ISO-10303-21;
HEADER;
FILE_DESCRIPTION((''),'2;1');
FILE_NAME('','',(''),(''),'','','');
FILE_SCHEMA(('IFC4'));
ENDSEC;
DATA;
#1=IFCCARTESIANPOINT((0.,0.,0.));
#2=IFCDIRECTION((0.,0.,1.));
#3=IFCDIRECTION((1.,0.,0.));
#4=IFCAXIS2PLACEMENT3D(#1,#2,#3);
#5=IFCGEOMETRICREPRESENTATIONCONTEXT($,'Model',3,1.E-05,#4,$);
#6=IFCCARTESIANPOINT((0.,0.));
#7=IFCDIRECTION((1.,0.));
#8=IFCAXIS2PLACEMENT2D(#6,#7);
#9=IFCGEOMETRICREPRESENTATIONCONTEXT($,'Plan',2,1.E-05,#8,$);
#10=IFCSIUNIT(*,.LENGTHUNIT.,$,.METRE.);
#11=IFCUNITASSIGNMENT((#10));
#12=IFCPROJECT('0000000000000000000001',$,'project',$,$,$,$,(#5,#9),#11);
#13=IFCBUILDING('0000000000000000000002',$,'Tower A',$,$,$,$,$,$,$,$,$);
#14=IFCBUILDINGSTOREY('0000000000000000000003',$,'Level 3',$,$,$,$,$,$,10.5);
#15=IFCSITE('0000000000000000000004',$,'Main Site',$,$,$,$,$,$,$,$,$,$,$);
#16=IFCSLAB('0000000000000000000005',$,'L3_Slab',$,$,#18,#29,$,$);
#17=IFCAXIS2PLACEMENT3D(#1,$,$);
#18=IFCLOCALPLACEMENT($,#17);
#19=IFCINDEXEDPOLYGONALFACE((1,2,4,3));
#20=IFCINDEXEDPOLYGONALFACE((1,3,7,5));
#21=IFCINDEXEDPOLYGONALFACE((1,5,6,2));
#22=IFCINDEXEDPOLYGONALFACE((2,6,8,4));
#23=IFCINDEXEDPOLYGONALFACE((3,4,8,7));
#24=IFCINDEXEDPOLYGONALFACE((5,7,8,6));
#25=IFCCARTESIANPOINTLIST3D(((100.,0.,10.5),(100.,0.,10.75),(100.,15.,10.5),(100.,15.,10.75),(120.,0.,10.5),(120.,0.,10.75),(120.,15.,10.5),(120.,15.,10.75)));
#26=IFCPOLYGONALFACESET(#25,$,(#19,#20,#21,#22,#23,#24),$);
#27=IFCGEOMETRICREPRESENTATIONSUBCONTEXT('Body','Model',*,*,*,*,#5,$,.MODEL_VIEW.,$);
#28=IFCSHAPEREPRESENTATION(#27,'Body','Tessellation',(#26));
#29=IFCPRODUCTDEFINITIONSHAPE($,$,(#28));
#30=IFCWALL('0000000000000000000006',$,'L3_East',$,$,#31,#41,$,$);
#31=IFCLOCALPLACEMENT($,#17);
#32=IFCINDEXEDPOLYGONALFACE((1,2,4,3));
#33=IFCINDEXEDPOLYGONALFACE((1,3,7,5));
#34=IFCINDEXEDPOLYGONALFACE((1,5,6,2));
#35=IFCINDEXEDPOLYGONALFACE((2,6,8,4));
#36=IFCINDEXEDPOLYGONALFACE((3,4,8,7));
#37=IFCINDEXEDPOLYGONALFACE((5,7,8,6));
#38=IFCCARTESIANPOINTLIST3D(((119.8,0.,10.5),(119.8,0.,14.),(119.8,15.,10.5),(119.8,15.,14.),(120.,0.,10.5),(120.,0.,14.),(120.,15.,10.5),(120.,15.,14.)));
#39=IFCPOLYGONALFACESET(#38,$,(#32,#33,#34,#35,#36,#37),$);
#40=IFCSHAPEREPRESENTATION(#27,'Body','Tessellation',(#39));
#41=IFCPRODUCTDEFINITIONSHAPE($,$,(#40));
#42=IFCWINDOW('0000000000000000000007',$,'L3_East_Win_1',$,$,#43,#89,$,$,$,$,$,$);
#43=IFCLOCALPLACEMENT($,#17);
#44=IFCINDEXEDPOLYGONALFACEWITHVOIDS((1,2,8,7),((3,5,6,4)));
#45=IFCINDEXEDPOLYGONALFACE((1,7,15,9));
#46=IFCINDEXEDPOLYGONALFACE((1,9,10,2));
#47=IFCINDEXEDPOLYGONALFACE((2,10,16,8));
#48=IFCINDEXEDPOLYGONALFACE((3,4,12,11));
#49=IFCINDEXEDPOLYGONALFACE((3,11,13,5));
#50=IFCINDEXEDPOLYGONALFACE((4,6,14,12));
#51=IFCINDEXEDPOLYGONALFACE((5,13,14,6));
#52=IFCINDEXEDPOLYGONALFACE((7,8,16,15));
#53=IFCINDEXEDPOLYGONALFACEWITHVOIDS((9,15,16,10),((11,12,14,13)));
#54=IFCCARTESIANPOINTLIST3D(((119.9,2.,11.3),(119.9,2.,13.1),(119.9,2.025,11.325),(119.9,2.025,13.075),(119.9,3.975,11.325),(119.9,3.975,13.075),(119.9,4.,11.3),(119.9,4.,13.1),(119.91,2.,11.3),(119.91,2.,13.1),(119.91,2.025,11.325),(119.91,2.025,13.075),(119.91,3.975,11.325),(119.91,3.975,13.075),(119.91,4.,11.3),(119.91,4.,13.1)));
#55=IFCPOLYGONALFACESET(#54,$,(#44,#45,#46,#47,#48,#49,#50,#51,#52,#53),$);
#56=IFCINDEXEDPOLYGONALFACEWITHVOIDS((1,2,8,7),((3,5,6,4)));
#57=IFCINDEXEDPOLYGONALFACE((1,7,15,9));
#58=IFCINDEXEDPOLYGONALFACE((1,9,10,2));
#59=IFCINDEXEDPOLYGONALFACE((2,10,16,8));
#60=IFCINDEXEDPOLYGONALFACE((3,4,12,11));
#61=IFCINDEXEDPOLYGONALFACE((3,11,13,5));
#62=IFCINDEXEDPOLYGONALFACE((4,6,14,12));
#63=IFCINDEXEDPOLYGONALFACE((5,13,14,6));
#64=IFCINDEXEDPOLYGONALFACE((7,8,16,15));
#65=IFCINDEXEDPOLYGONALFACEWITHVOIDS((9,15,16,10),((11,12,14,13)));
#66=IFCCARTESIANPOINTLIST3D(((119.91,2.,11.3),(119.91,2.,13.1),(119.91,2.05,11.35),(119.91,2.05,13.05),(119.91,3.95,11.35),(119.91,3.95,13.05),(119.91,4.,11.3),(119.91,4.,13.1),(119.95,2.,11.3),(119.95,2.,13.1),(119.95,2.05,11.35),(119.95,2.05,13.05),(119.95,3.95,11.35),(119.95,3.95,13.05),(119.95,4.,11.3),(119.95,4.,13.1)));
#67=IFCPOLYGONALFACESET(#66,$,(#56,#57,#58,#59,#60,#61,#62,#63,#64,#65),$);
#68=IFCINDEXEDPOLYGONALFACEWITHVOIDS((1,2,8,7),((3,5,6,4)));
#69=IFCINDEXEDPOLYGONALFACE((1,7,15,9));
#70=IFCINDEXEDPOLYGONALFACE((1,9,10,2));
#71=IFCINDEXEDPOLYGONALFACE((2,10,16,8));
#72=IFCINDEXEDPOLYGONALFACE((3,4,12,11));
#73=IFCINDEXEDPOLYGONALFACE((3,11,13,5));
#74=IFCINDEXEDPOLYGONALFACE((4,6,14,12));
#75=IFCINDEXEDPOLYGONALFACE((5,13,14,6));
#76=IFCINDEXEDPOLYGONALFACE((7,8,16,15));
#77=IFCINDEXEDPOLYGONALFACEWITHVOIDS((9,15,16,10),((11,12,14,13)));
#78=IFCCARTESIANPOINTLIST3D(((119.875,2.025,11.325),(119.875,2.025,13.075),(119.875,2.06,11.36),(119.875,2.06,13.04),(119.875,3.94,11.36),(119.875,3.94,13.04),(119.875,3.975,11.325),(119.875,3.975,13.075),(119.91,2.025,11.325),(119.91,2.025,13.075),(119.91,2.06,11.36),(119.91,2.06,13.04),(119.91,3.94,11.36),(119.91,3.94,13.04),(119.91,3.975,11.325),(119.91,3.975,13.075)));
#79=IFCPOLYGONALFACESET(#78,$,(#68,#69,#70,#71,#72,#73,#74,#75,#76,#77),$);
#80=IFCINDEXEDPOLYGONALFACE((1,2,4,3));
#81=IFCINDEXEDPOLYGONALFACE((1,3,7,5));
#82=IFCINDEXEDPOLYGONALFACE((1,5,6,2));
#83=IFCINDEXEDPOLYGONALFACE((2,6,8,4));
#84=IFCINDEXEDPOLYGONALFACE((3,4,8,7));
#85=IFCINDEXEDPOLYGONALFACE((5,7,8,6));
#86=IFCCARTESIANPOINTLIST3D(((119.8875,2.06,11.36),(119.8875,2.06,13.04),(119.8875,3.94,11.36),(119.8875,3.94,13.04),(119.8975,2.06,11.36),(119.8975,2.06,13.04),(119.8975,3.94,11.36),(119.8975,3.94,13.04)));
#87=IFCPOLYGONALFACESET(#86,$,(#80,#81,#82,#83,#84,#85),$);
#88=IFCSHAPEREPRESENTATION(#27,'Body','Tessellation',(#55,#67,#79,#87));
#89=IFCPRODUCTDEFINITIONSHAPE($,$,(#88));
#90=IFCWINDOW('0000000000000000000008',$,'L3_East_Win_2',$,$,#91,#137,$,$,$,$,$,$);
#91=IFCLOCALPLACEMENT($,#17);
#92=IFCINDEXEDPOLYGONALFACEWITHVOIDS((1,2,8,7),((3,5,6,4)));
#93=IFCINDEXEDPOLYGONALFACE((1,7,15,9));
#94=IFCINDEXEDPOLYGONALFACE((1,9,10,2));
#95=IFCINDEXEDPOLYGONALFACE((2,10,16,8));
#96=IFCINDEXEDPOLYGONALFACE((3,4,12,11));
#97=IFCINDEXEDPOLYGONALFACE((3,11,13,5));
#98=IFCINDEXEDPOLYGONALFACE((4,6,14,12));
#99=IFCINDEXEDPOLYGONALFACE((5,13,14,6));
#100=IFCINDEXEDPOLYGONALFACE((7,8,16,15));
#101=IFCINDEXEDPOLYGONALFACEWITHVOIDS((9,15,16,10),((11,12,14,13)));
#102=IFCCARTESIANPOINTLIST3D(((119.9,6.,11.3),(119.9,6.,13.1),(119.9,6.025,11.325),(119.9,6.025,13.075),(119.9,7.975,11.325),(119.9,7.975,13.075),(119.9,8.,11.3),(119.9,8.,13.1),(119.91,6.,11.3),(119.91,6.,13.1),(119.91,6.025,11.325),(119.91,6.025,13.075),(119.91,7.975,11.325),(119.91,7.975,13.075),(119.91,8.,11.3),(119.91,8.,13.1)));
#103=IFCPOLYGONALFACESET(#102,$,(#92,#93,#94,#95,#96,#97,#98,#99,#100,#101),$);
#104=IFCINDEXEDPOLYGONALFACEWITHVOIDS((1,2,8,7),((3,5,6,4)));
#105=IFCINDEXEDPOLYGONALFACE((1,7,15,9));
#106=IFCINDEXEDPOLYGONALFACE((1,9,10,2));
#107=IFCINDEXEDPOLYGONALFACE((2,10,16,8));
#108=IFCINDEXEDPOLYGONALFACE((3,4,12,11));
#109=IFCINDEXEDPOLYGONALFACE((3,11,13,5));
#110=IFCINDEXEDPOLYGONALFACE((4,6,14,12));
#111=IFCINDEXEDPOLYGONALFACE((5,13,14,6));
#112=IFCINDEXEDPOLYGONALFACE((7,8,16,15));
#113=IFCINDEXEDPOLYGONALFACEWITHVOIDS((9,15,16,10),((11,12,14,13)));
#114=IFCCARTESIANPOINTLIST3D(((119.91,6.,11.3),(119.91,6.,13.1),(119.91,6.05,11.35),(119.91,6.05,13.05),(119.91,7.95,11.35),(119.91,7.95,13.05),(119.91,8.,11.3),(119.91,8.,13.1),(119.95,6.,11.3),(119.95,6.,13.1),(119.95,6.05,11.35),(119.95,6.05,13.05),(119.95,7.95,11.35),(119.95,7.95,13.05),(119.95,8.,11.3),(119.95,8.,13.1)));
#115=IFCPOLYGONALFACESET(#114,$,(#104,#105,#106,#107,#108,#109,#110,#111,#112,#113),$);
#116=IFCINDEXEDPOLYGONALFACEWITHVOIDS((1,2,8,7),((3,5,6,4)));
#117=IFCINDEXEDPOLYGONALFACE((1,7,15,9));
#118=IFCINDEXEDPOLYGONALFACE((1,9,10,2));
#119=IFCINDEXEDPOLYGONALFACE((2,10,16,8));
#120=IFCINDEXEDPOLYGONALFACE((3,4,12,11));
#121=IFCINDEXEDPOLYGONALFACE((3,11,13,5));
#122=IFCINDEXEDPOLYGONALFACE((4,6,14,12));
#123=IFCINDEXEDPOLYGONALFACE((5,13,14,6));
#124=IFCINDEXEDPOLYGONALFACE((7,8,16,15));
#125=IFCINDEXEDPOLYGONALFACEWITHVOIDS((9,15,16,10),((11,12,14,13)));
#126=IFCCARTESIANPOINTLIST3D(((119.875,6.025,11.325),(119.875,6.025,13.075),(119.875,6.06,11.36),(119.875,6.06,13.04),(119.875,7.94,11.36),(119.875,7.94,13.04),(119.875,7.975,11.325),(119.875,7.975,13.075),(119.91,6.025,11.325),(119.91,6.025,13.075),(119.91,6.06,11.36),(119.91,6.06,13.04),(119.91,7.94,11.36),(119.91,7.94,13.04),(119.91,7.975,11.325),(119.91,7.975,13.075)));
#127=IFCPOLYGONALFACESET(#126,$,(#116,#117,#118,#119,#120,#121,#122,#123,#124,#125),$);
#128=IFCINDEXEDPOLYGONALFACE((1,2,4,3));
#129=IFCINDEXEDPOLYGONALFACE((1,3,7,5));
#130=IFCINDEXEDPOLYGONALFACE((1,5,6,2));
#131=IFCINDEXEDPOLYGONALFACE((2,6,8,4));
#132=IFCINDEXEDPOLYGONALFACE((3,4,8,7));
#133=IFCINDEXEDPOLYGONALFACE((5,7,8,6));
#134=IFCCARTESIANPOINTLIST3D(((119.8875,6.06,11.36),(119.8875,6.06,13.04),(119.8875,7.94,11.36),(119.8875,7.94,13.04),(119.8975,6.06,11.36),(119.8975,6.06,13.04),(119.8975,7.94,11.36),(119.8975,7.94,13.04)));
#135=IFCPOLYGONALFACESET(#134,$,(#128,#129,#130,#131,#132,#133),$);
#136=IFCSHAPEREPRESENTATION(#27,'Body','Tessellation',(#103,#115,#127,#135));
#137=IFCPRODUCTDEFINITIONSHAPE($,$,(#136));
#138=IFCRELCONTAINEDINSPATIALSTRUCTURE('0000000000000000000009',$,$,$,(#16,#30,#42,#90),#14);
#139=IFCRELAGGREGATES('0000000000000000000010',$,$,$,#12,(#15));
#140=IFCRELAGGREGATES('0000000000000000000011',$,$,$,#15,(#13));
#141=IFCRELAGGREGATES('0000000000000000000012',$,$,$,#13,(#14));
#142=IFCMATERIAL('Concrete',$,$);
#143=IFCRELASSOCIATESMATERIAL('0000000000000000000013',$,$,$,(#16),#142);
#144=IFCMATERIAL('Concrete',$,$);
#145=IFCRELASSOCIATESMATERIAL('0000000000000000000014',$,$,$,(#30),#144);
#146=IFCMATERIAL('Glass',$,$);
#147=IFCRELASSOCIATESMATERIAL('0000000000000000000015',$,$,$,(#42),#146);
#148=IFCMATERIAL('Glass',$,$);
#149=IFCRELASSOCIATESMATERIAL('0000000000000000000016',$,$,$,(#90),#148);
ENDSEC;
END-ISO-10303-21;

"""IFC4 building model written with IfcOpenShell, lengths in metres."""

from ifc_helpers import new_model, si_unit, frame, origin_with_axes, origin_2d_with_axis, place, context, subcontext, project, spatial, line, indexed_curve, outline, extrude, material, element, fill, save


model = new_model("IFC4")

# Units and contexts
model_context = context("Model", 3, precision=1e-05, world=origin_with_axes())
plan_context = context("Plan", 2, precision=1e-05, world=origin_2d_with_axis())
body_context = subcontext(model_context, "Body", "Model", "MODEL_VIEW")
ifc_project = project(units=[si_unit("LENGTHUNIT", "METRE")], contexts=[model_context, plan_context])

# Site, building, storey
site = spatial("IfcSite", under=ifc_project, Name="Main Site")
building = spatial("IfcBuilding", under=site, Name="Tower A")
storey = spatial("IfcBuildingStorey", under=building, Name="Level 3", Elevation=10.5)

# Slab
ifc_material_1 = material(Name="Concrete")
slab_placement = place(None, frame((100.0, 0.0, 10.5), z_axis=(0.0, 0.0, 1.0), x_axis=(1.0, 0.0, 0.0)))
element("IfcSlab", 1, at=slab_placement, inside=storey, material=ifc_material_1, Name="L3_Slab", context=body_context, shape_type="SweptSolid", body=[
    extrude(outline(indexed_curve([(0.0, 0.0), (20.0, 0.0), (20.0, 15.0), (0.0, 15.0)])), None, (0.0, 0.0, 1.0), 0.25),
])

# Wall, openings, windows
ifc_material_2 = material(Name="Concrete")
wall_1_placement = place(None, frame((120.0, 0.0, 10.5), z_axis=(0.0, 0.0, 1.0), x_axis=(0.0, 1.0, 0.0)))
wall_1 = element("IfcWall", 2, at=wall_1_placement, inside=storey, material=ifc_material_2, Name="L3_East", context=body_context, shape_type="SweptSolid", body=[
    extrude(outline(indexed_curve([(0.0, 0.0), (0.0, 0.2), (15.0, 0.2), (15.0, 0.0), (0.0, 0.0)], self_intersect=False)), origin_with_axes(), (0.0, 0.0, 1.0), 3.5),
])
opening_1_placement = place(wall_1_placement, frame((2.0, 0.0, 0.8), z_axis=(0.0, 0.0, 1.0), x_axis=(0.0, -1.0, 0.0)))
opening_1 = element("IfcOpeningElement", 3, at=opening_1_placement, cuts=wall_1, context=body_context, shape_type="SweptSolid", body=[
    extrude(outline(indexed_curve([(0.0, 0.0), (0.0, 0.25), (2.0, 0.25), (2.0, 0.0), (0.0, 0.0)], self_intersect=False)), origin_with_axes(), (0.0, 0.0, 1.0), 1.8),
])
opening_2_placement = place(wall_1_placement, frame((6.0, 0.0, 0.8), z_axis=(0.0, 0.0, 1.0), x_axis=(0.0, -1.0, 0.0)))
opening_2 = element("IfcOpeningElement", 4, at=opening_2_placement, cuts=wall_1, context=body_context, shape_type="SweptSolid", body=[
    extrude(outline(indexed_curve([(0.0, 0.0), (0.0, 0.25), (2.0, 0.25), (2.0, 0.0), (0.0, 0.0)], self_intersect=False)), origin_with_axes(), (0.0, 0.0, 1.0), 1.8),
])
ifc_material_3 = material(Name="Glass")
window_1_placement = place(None, frame((120.0, 2.0, 11.3), z_axis=(0.0, 0.0, 1.0), x_axis=(0.0, 1.0, 0.0)))
window_1 = element("IfcWindow", 5, at=window_1_placement, inside=storey, material=ifc_material_3, Name="L3_East_Win_1", context=body_context, shape_type="SweptSolid", body=[
    extrude(outline(indexed_curve([(0.0, 0.0), (2.0, 0.0), (2.0, 1.8), (0.0, 1.8)], segments=[line(1, 2, 3, 4, 1)]), holes=[indexed_curve([(0.025, 0.025), (1.975, 0.025), (1.975, 1.775), (0.025, 1.775)], segments=[line(1, 2, 3, 4, 1)])]), frame((0.0, 0.09, 0.0), z_axis=(0.0, -1.0, 0.0), x_axis=(1.0, 0.0, 0.0)), (0.0, 0.0, -1.0), 0.01),
    extrude(outline(indexed_curve([(0.0, 0.0), (2.0, 0.0), (2.0, 1.8), (0.0, 1.8)], segments=[line(1, 2, 3, 4, 1)]), holes=[indexed_curve([(0.05, 0.05), (1.95, 0.05), (1.95, 1.75), (0.05, 1.75)], segments=[line(1, 2, 3, 4, 1)])]), frame((0.0, 0.05, 0.0), z_axis=(0.0, -1.0, 0.0), x_axis=(1.0, 0.0, 0.0)), (0.0, 0.0, -1.0), 0.04),
    extrude(outline(indexed_curve([(0.0, 0.0), (1.95, 0.0), (1.95, 1.75), (0.0, 1.75)], segments=[line(1, 2, 3, 4, 1)]), holes=[indexed_curve([(0.035, 0.035), (1.915, 0.035), (1.915, 1.715), (0.035, 1.715)], segments=[line(1, 2, 3, 4, 1)])]), frame((0.025, 0.09, 0.025), z_axis=(0.0, -1.0, 0.0), x_axis=(1.0, 0.0, 0.0)), (0.0, 0.0, -1.0), 0.035),
    extrude(outline(indexed_curve([(0.035, 0.035), (1.915, 0.035), (1.915, 1.715), (0.035, 1.715)], segments=[line(1, 2, 3, 4, 1)])), frame((0.025, 0.1025, 0.025), z_axis=(0.0, -1.0, 0.0), x_axis=(1.0, 0.0, 0.0)), (0.0, 0.0, -1.0), 0.01),
])
fill(opening_1, window_1)
ifc_material_4 = material(Name="Glass")
window_2_placement = place(None, frame((120.0, 6.0, 11.3), z_axis=(0.0, 0.0, 1.0), x_axis=(0.0, 1.0, 0.0)))
window_2 = element("IfcWindow", 6, at=window_2_placement, inside=storey, material=ifc_material_4, Name="L3_East_Win_2", context=body_context, shape_type="SweptSolid", body=[
    extrude(outline(indexed_curve([(0.0, 0.0), (2.0, 0.0), (2.0, 1.8), (0.0, 1.8)], segments=[line(1, 2, 3, 4, 1)]), holes=[indexed_curve([(0.025, 0.025), (1.975, 0.025), (1.975, 1.775), (0.025, 1.775)], segments=[line(1, 2, 3, 4, 1)])]), frame((0.0, 0.09, 0.0), z_axis=(0.0, -1.0, 0.0), x_axis=(1.0, 0.0, 0.0)), (0.0, 0.0, -1.0), 0.01),
    extrude(outline(indexed_curve([(0.0, 0.0), (2.0, 0.0), (2.0, 1.8), (0.0, 1.8)], segments=[line(1, 2, 3, 4, 1)]), holes=[indexed_curve([(0.05, 0.05), (1.95, 0.05), (1.95, 1.75), (0.05, 1.75)], segments=[line(1, 2, 3, 4, 1)])]), frame((0.0, 0.05, 0.0), z_axis=(0.0, -1.0, 0.0), x_axis=(1.0, 0.0, 0.0)), (0.0, 0.0, -1.0), 0.04),
    extrude(outline(indexed_curve([(0.0, 0.0), (1.95, 0.0), (1.95, 1.75), (0.0, 1.75)], segments=[line(1, 2, 3, 4, 1)]), holes=[indexed_curve([(0.035, 0.035), (1.915, 0.035), (1.915, 1.715), (0.035, 1.715)], segments=[line(1, 2, 3, 4, 1)])]), frame((0.025, 0.09, 0.025), z_axis=(0.0, -1.0, 0.0), x_axis=(1.0, 0.0, 0.0)), (0.0, 0.0, -1.0), 0.035),
    extrude(outline(indexed_curve([(0.035, 0.035), (1.915, 0.035), (1.915, 1.715), (0.035, 1.715)], segments=[line(1, 2, 3, 4, 1)])), frame((0.025, 0.1025, 0.025), z_axis=(0.0, -1.0, 0.0), x_axis=(1.0, 0.0, 0.0)), (0.0, 0.0, -1.0), 0.01),
])
fill(opening_2, window_2)

save(model, "model.ifc")
